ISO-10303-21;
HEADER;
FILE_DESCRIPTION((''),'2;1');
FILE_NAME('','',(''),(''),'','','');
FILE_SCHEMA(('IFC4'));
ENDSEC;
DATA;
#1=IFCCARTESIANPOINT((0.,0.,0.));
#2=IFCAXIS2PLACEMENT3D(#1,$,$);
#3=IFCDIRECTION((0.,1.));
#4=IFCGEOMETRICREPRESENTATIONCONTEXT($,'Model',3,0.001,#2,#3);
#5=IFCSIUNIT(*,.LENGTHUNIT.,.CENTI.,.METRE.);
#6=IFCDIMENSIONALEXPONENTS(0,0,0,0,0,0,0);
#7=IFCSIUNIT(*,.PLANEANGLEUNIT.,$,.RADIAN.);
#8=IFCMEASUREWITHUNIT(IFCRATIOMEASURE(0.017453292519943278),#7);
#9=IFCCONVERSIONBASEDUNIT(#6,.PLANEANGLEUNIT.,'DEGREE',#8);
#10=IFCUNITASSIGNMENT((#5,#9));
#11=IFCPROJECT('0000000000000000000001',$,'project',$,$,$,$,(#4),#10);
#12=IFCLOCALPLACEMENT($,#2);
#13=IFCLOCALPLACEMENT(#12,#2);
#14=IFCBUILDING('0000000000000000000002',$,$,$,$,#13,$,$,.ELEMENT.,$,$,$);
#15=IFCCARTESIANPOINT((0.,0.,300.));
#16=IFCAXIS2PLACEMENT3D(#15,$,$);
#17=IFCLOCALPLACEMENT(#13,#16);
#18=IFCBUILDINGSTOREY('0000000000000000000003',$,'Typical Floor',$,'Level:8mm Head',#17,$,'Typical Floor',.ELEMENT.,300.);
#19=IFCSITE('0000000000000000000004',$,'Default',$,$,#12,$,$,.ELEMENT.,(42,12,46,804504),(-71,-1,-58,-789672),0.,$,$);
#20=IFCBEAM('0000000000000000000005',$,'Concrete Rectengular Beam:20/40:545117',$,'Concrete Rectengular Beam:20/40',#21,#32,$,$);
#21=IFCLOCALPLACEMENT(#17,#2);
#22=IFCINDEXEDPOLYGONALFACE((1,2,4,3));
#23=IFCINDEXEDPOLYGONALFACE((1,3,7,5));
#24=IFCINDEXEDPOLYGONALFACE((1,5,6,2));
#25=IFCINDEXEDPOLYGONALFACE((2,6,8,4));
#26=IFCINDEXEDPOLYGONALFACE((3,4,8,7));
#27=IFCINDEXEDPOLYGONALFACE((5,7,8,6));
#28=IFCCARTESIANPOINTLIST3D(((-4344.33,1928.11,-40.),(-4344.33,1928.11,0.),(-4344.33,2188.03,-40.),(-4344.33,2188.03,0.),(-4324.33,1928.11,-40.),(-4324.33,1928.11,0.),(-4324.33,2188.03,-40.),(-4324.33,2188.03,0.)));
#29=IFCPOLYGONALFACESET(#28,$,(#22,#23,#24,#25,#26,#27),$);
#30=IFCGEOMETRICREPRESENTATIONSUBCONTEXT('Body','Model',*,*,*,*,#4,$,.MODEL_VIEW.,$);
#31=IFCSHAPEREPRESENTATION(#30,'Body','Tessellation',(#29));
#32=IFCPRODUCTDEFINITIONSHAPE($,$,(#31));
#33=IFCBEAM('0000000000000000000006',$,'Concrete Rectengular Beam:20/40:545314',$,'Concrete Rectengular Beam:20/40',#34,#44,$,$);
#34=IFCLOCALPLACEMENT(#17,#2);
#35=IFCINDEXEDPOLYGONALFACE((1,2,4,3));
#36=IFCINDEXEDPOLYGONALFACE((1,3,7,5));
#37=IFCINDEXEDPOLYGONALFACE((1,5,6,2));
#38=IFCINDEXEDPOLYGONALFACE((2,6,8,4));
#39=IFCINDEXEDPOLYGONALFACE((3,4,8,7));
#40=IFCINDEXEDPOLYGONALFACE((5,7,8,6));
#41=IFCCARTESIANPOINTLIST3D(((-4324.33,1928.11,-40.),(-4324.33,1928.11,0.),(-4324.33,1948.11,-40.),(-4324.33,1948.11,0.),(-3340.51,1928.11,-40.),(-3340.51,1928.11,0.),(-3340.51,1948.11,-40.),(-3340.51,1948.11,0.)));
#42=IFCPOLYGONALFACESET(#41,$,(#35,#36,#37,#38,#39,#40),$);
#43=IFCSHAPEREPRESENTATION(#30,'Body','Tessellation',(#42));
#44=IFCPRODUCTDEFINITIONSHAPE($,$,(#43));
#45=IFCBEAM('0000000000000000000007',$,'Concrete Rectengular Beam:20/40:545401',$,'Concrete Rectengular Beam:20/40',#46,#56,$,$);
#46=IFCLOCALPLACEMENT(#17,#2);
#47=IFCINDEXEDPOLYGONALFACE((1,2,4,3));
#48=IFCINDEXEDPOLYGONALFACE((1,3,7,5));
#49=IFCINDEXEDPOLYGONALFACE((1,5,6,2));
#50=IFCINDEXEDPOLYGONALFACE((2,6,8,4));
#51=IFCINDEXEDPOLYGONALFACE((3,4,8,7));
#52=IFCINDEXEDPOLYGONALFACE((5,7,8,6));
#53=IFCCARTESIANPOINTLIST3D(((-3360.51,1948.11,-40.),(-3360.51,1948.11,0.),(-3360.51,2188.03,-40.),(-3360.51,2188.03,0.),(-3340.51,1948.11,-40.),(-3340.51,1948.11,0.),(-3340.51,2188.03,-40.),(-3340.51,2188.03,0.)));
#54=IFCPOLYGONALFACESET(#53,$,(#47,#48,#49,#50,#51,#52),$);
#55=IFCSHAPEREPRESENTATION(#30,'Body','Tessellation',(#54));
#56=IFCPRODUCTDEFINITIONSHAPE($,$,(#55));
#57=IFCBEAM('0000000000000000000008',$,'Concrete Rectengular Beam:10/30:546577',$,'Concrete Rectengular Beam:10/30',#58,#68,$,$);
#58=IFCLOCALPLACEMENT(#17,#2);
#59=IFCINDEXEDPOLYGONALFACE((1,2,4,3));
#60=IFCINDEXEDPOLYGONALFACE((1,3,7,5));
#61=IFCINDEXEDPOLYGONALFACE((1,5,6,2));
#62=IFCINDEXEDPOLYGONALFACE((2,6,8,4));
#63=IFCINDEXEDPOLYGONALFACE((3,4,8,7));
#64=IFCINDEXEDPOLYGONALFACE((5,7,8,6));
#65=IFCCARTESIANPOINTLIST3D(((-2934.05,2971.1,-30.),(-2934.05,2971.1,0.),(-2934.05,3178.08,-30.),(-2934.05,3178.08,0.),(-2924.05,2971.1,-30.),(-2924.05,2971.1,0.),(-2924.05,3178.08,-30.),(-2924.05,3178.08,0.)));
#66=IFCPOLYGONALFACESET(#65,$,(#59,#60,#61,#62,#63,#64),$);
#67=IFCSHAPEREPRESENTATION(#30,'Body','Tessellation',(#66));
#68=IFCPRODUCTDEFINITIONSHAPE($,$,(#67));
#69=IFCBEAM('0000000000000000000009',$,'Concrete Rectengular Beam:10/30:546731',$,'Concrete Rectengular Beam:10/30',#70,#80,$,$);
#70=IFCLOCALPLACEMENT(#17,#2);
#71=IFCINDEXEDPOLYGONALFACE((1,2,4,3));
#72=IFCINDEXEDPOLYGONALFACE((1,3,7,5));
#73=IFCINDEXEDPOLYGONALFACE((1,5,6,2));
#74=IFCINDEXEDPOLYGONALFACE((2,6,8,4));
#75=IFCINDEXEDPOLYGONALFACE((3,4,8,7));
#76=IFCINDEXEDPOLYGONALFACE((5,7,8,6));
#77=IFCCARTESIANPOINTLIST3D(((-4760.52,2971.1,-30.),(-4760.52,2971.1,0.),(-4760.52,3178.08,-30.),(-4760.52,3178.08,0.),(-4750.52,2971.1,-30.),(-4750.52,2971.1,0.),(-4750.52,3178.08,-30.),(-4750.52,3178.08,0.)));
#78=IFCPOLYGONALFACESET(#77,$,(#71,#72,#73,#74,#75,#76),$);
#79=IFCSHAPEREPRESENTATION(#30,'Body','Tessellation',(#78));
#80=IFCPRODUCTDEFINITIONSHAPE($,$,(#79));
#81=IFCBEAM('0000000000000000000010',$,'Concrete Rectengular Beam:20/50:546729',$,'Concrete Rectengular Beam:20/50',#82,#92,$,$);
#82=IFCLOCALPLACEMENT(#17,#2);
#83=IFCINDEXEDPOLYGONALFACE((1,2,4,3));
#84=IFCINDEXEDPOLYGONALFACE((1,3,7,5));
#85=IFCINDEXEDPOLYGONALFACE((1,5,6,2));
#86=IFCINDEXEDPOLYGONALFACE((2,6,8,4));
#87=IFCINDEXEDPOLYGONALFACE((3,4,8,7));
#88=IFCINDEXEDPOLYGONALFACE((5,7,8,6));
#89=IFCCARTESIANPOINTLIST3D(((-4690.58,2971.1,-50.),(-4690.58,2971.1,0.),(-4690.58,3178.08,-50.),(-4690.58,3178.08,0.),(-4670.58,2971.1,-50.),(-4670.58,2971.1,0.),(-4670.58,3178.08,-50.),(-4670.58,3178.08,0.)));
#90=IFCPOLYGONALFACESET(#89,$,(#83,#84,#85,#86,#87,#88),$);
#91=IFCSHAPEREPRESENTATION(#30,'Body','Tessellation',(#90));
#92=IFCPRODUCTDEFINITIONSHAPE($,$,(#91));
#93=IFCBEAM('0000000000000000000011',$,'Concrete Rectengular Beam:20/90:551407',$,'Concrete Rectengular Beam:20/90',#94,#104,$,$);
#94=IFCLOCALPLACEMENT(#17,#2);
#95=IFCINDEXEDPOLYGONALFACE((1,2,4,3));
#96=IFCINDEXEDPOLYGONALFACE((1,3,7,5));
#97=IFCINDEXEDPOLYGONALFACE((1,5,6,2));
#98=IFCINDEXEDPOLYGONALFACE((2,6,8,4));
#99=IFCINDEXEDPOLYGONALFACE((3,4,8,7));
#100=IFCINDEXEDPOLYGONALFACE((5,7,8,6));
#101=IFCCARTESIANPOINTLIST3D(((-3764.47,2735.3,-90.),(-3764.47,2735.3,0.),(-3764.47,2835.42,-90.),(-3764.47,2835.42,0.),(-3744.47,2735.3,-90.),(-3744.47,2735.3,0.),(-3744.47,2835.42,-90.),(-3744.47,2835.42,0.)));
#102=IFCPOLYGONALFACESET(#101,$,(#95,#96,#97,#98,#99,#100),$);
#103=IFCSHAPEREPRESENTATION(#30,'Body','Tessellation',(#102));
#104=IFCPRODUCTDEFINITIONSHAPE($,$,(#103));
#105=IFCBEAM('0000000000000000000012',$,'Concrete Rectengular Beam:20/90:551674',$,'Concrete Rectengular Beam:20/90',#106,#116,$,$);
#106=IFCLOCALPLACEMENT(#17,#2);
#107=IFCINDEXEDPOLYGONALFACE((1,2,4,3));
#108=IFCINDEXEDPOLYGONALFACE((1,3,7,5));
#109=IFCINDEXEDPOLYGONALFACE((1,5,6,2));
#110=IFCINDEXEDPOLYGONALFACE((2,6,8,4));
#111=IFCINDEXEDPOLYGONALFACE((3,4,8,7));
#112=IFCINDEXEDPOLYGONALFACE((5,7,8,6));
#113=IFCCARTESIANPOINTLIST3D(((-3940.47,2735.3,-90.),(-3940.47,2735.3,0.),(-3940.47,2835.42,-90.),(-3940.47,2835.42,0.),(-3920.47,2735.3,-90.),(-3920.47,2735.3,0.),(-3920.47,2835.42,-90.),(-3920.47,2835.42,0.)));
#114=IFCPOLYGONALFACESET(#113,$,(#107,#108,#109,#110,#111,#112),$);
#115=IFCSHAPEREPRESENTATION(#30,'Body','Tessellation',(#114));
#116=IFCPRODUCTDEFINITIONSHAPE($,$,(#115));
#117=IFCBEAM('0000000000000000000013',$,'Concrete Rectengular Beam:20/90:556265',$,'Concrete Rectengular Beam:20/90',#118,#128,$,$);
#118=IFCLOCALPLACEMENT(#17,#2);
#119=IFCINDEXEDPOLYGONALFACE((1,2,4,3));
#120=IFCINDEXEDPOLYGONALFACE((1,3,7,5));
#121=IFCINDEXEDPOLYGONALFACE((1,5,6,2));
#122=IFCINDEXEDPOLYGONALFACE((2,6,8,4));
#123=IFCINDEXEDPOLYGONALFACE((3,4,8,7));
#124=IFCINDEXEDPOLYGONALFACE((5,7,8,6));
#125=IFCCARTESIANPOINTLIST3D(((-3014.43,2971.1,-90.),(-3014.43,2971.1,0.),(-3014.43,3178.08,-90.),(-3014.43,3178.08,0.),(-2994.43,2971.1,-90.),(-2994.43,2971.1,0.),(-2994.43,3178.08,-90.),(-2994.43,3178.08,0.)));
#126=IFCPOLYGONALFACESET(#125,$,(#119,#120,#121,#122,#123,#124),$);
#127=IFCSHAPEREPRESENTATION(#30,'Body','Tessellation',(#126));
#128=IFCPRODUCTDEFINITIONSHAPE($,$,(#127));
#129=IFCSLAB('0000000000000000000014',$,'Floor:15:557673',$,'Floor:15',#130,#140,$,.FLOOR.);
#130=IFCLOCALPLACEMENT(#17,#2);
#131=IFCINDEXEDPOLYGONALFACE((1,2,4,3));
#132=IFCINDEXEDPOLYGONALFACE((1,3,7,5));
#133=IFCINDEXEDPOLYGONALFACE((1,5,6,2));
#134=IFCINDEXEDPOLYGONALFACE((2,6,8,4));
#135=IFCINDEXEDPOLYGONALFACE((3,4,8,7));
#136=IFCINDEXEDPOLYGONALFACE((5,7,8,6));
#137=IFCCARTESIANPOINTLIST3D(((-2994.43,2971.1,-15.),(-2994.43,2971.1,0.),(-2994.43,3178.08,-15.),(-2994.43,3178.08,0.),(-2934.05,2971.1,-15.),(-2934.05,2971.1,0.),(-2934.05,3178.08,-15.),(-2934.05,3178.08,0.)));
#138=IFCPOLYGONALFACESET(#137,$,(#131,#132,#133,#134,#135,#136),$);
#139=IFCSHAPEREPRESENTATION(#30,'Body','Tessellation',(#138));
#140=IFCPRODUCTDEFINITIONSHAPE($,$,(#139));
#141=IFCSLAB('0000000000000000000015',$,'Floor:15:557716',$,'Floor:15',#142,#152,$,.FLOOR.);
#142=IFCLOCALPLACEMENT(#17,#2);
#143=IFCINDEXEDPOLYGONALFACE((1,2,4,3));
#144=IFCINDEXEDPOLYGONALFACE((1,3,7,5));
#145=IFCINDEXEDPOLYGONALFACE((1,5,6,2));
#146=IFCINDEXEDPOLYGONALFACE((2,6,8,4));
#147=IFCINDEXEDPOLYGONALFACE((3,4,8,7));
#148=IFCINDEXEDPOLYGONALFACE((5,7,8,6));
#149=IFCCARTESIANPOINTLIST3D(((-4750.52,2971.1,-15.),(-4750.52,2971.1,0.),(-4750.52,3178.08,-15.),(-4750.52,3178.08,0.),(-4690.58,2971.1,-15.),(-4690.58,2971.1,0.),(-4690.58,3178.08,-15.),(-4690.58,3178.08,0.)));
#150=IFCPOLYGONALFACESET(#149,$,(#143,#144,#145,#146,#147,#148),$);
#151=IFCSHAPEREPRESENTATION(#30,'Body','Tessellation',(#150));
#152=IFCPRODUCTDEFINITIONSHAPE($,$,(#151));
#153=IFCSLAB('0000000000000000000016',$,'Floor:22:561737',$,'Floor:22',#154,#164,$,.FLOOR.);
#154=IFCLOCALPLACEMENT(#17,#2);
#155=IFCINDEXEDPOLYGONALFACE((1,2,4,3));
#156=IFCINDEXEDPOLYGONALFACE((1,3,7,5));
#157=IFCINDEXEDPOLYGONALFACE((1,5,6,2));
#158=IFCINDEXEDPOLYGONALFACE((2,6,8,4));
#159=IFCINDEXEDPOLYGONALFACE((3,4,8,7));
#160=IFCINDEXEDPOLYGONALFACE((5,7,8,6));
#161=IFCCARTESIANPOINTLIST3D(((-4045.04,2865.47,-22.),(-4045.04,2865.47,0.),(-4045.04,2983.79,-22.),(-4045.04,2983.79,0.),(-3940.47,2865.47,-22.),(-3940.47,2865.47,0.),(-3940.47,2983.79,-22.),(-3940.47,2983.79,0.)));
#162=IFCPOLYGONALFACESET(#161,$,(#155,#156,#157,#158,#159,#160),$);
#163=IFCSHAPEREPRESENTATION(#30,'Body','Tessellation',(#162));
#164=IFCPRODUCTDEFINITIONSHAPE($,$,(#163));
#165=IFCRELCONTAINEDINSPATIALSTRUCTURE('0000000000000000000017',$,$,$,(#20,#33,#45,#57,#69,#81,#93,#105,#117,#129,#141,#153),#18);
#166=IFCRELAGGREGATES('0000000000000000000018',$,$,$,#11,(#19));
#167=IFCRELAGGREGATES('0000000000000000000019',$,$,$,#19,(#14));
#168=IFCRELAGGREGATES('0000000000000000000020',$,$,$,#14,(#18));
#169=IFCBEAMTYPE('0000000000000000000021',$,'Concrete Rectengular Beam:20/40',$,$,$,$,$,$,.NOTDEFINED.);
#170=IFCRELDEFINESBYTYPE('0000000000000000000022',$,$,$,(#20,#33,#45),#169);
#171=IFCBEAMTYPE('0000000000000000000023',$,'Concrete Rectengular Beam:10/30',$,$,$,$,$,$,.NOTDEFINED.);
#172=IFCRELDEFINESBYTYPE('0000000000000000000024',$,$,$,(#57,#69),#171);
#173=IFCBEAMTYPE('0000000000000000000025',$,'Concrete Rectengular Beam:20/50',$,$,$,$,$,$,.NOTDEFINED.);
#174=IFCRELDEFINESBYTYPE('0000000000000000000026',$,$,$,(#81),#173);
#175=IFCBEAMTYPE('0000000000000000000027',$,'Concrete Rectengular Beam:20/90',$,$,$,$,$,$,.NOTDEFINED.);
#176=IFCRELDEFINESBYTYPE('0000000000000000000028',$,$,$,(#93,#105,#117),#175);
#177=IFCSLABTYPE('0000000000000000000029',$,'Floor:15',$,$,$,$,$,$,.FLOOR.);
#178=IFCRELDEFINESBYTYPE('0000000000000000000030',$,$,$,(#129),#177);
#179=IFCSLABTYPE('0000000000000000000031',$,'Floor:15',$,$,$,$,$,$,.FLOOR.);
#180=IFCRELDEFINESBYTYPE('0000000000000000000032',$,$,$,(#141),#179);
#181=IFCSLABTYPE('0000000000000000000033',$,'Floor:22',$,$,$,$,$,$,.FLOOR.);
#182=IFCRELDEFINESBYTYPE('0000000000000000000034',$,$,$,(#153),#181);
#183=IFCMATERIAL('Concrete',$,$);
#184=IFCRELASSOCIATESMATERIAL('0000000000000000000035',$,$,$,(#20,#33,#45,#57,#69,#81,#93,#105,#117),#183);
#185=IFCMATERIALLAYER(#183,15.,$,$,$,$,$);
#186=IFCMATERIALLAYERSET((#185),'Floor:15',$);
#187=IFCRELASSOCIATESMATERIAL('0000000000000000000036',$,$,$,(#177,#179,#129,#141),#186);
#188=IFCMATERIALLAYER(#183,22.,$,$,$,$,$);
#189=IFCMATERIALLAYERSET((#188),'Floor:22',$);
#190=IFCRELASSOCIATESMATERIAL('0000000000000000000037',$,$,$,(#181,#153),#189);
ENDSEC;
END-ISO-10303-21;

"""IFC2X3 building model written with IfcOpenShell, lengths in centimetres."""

from ifc_helpers import new_model, entity, si_unit, converted_unit, direction, frame, frame_2d, origin, origin_2d_with_axis, place, context, subcontext, project, spatial, rectangle, extrude, material, layer, layer_set, layer_usage, type_object, element, save


model = new_model("IFC2X3")

# Units and contexts
model_context = context("Model", 3, precision=0.001, world=origin(), true_north=direction((0.0, 1.0)))
body_context = subcontext(model_context, "Body", "Model", "MODEL_VIEW")
ifc_project = project(units=[si_unit("LENGTHUNIT", "METRE", prefix="CENTI"), converted_unit("PLANEANGLEUNIT", "DEGREE", entity("IfcRatioMeasure", 0.017453292519943278), si_unit("PLANEANGLEUNIT", "RADIAN"), dimensions=[0, 0, 0, 0, 0, 0, 0])], contexts=[model_context])

# Site, building, storey
site_placement = place(None, origin())
site = spatial("IfcSite", under=ifc_project, at=site_placement, Name="Default", CompositionType="ELEMENT", RefLatitude=(42, 12, 46, 804504), RefLongitude=(-71, -1, -58, -789672), RefElevation=0.0)
building_placement = place(site_placement, origin())
building = spatial("IfcBuilding", under=site, at=building_placement, CompositionType="ELEMENT")
storey_placement = place(building_placement, frame((0.0, 0.0, 300.0)))
storey = spatial("IfcBuildingStorey", under=building, at=storey_placement, Name="Typical Floor", ObjectType="Level:8mm Head", LongName="Typical Floor", CompositionType="ELEMENT", Elevation=300.0)

# Beams
ifc_material = material(Name="Concrete")
beam_type_1 = type_object("IfcBeamType", Name="Concrete Rectengular Beam:20/40", PredefinedType="NOTDEFINED")
beam_1_placement = place(storey_placement, frame((-4334.33, 2198.03, 0.0), z_axis=(0.0, 0.0, 1.0), x_axis=(0.0, -1.0, 0.0)))
element("IfcBeam", 1, at=beam_1_placement, inside=storey, type_object=beam_type_1, material=ifc_material, Name="Concrete Rectengular Beam:20/40:545117", ObjectType="Concrete Rectengular Beam:20/40", context=body_context, shape_type="SweptSolid", body=[
    extrude(rectangle(XDim=40.0, YDim=20.0, at=origin_2d_with_axis()), frame((10.0, 0.0, -20.0), z_axis=(1.0, 0.0, 0.0), x_axis=(0.0, 0.0, -1.0)), (0.0, 0.0, 1.0), 259.92),
])
beam_2_placement = place(storey_placement, frame((-4334.33, 1948.11, 0.0)))
element("IfcBeam", 2, at=beam_2_placement, inside=storey, type_object=beam_type_1, material=ifc_material, Name="Concrete Rectengular Beam:20/40:545314", ObjectType="Concrete Rectengular Beam:20/40", context=body_context, shape_type="SweptSolid", body=[
    extrude(rectangle(XDim=40.0, YDim=20.0, at=frame_2d((0.0, 0.0), x_axis=(1.0, 0.0))), frame((10.0, -10.0, -20.0), z_axis=(1.0, 0.0, 0.0), x_axis=(0.0, 0.0, -1.0)), (0.0, 0.0, 1.0), 983.82),
])
beam_3_placement = place(storey_placement, frame((-3360.51, 1948.11, 0.0), z_axis=(0.0, 0.0, 1.0), x_axis=(0.0, 1.0, 0.0)))
element("IfcBeam", 3, at=beam_3_placement, inside=storey, type_object=beam_type_1, material=ifc_material, Name="Concrete Rectengular Beam:20/40:545401", ObjectType="Concrete Rectengular Beam:20/40", context=body_context, shape_type="SweptSolid", body=[
    extrude(rectangle(XDim=40.0, YDim=20.0, at=frame_2d((0.0, 0.0), x_axis=(1.0, 0.0))), frame((0.0, -10.0, -20.0), z_axis=(1.0, 0.0, 0.0), x_axis=(0.0, 0.0, -1.0)), (0.0, 0.0, 1.0), 239.92),
])
beam_type_2 = type_object("IfcBeamType", Name="Concrete Rectengular Beam:10/30", PredefinedType="NOTDEFINED")
beam_4_placement = place(storey_placement, frame((-2934.05, 2961.1, 0.0), z_axis=(0.0, 0.0, 1.0), x_axis=(0.0, 1.0, 0.0)))
element("IfcBeam", 4, at=beam_4_placement, inside=storey, type_object=beam_type_2, material=ifc_material, Name="Concrete Rectengular Beam:10/30:546577", ObjectType="Concrete Rectengular Beam:10/30", context=body_context, shape_type="SweptSolid", body=[
    extrude(rectangle(XDim=30.0, YDim=10.0, at=origin_2d_with_axis()), frame((10.0, -5.0, -15.0), z_axis=(1.0, 0.0, 0.0), x_axis=(0.0, 0.0, -1.0)), (0.0, 0.0, 1.0), 206.99),
])
beam_5_placement = place(storey_placement, frame((-4750.52, 2961.1, 0.0), z_axis=(0.0, 0.0, 1.0), x_axis=(0.0, 1.0, 0.0)))
element("IfcBeam", 5, at=beam_5_placement, inside=storey, type_object=beam_type_2, material=ifc_material, Name="Concrete Rectengular Beam:10/30:546731", ObjectType="Concrete Rectengular Beam:10/30", context=body_context, shape_type="SweptSolid", body=[
    extrude(rectangle(XDim=30.0, YDim=10.0, at=origin_2d_with_axis()), frame((10.0, 5.0, -15.0), z_axis=(1.0, 0.0, 0.0), x_axis=(0.0, 0.0, -1.0)), (0.0, 0.0, 1.0), 206.99),
])
beam_type_3 = type_object("IfcBeamType", Name="Concrete Rectengular Beam:20/50", PredefinedType="NOTDEFINED")
beam_6_placement = place(storey_placement, frame((-4670.58, 2961.1, 0.0), z_axis=(0.0, 0.0, 1.0), x_axis=(0.0, 1.0, 0.0)))
element("IfcBeam", 6, at=beam_6_placement, inside=storey, type_object=beam_type_3, material=ifc_material, Name="Concrete Rectengular Beam:20/50:546729", ObjectType="Concrete Rectengular Beam:20/50", context=body_context, shape_type="SweptSolid", body=[
    extrude(rectangle(XDim=50.0, YDim=20.0, at=origin_2d_with_axis()), frame((10.0, 10.0, -25.0), z_axis=(1.0, 0.0, 0.0), x_axis=(0.0, 0.0, -1.0)), (0.0, 0.0, 1.0), 206.99),
])
beam_type_4 = type_object("IfcBeamType", Name="Concrete Rectengular Beam:20/90", PredefinedType="NOTDEFINED")
beam_7_placement = place(storey_placement, frame((-3744.47, 2845.45, 0.0), z_axis=(0.0, 0.0, 1.0), x_axis=(0.0, -1.0, 0.0)))
element("IfcBeam", 7, at=beam_7_placement, inside=storey, type_object=beam_type_4, material=ifc_material, Name="Concrete Rectengular Beam:20/90:551407", ObjectType="Concrete Rectengular Beam:20/90", context=body_context, shape_type="SweptSolid", body=[
    extrude(rectangle(XDim=90.0, YDim=20.0, at=origin_2d_with_axis()), frame((10.03, -10.0, -45.0), z_axis=(1.0, 0.0, 0.0), x_axis=(0.0, 0.0, -1.0)), (0.0, 0.0, 1.0), 100.12),
])
beam_8_placement = place(storey_placement, frame((-3920.47, 2855.37, 0.0), z_axis=(0.0, 0.0, 1.0), x_axis=(0.0, -1.0, 0.0)))
element("IfcBeam", 8, at=beam_8_placement, inside=storey, type_object=beam_type_4, material=ifc_material, Name="Concrete Rectengular Beam:20/90:551674", ObjectType="Concrete Rectengular Beam:20/90", context=body_context, shape_type="SweptSolid", body=[
    extrude(rectangle(XDim=90.0, YDim=20.0, at=origin_2d_with_axis()), frame((19.95, -10.0, -45.0), z_axis=(1.0, 0.0, 0.0), x_axis=(0.0, 0.0, -1.0)), (0.0, 0.0, 1.0), 100.12),
])
beam_9_placement = place(storey_placement, frame((-2994.43, 3190.58, 0.0), z_axis=(0.0, 0.0, 1.0), x_axis=(0.0, -1.0, 0.0)))
element("IfcBeam", 9, at=beam_9_placement, inside=storey, type_object=beam_type_4, material=ifc_material, Name="Concrete Rectengular Beam:20/90:556265", ObjectType="Concrete Rectengular Beam:20/90", context=body_context, shape_type="SweptSolid", body=[
    extrude(rectangle(XDim=90.0, YDim=20.0, at=frame_2d((0.0, 0.0), x_axis=(1.0, 0.0))), frame((12.5, -10.0, -45.0), z_axis=(1.0, 0.0, 0.0), x_axis=(0.0, 0.0, -1.0)), (0.0, 0.0, 1.0), 206.99),
])

# Slabs
ifc_layer_1 = layer(ifc_material, 22.0)
ifc_layer_set_1 = layer_set([ifc_layer_1], Name="Floor:22")
ifc_layer_2 = layer(ifc_material, 15.0)
ifc_layer_set_2 = layer_set([ifc_layer_2], Name="Floor:15")
ifc_layer_usage_1 = layer_usage(ifc_layer_set_2, "AXIS3", "POSITIVE", 0.0)
slab_type_1 = type_object("IfcSlabType", Name="Floor:15", PredefinedType="FLOOR", material=ifc_layer_set_2)
slab_1_placement = place(storey_placement, origin())
element("IfcSlab", 10, at=slab_1_placement, inside=storey, type_object=slab_type_1, material=ifc_layer_usage_1, Name="Floor:15:557673", ObjectType="Floor:15", PredefinedType="FLOOR", context=body_context, shape_type="SweptSolid", body=[
    extrude(rectangle(XDim=206.99, YDim=60.38, at=origin_2d_with_axis()), frame((-2964.24, 3074.59, 0.0), z_axis=(0.0, 0.0, -1.0), x_axis=(0.0, 1.0, 0.0)), (0.0, 0.0, 1.0), 15.0),
])
ifc_layer_usage_2 = layer_usage(ifc_layer_set_2, "AXIS3", "POSITIVE", 0.0)
slab_type_2 = type_object("IfcSlabType", Name="Floor:15", PredefinedType="FLOOR", material=ifc_layer_set_2)
slab_2_placement = place(storey_placement, origin())
element("IfcSlab", 11, at=slab_2_placement, inside=storey, type_object=slab_type_2, material=ifc_layer_usage_2, Name="Floor:15:557716", ObjectType="Floor:15", PredefinedType="FLOOR", context=body_context, shape_type="SweptSolid", body=[
    extrude(rectangle(XDim=206.99, YDim=59.94, at=frame_2d((0.0, 0.0), x_axis=(1.0, 0.0))), frame((-4720.55, 3074.59, 0.0), z_axis=(0.0, 0.0, -1.0), x_axis=(0.0, 1.0, 0.0)), (0.0, 0.0, 1.0), 15.0),
])
ifc_layer_usage_3 = layer_usage(ifc_layer_set_1, "AXIS3", "POSITIVE", 0.0)
slab_type_3 = type_object("IfcSlabType", Name="Floor:22", PredefinedType="FLOOR", material=ifc_layer_set_1)
slab_3_placement = place(storey_placement, origin())
element("IfcSlab", 12, at=slab_3_placement, inside=storey, type_object=slab_type_3, material=ifc_layer_usage_3, Name="Floor:22:561737", ObjectType="Floor:22", PredefinedType="FLOOR", context=body_context, shape_type="SweptSolid", body=[
    extrude(rectangle(XDim=118.32, YDim=104.56, at=frame_2d((0.0, 0.0), x_axis=(1.0, 0.0))), frame((-3992.75, 2924.63, 0.0), z_axis=(0.0, 0.0, -1.0), x_axis=(0.0, 1.0, 0.0)), (0.0, 0.0, 1.0), 22.0),
])

save(model, "model.ifc")
